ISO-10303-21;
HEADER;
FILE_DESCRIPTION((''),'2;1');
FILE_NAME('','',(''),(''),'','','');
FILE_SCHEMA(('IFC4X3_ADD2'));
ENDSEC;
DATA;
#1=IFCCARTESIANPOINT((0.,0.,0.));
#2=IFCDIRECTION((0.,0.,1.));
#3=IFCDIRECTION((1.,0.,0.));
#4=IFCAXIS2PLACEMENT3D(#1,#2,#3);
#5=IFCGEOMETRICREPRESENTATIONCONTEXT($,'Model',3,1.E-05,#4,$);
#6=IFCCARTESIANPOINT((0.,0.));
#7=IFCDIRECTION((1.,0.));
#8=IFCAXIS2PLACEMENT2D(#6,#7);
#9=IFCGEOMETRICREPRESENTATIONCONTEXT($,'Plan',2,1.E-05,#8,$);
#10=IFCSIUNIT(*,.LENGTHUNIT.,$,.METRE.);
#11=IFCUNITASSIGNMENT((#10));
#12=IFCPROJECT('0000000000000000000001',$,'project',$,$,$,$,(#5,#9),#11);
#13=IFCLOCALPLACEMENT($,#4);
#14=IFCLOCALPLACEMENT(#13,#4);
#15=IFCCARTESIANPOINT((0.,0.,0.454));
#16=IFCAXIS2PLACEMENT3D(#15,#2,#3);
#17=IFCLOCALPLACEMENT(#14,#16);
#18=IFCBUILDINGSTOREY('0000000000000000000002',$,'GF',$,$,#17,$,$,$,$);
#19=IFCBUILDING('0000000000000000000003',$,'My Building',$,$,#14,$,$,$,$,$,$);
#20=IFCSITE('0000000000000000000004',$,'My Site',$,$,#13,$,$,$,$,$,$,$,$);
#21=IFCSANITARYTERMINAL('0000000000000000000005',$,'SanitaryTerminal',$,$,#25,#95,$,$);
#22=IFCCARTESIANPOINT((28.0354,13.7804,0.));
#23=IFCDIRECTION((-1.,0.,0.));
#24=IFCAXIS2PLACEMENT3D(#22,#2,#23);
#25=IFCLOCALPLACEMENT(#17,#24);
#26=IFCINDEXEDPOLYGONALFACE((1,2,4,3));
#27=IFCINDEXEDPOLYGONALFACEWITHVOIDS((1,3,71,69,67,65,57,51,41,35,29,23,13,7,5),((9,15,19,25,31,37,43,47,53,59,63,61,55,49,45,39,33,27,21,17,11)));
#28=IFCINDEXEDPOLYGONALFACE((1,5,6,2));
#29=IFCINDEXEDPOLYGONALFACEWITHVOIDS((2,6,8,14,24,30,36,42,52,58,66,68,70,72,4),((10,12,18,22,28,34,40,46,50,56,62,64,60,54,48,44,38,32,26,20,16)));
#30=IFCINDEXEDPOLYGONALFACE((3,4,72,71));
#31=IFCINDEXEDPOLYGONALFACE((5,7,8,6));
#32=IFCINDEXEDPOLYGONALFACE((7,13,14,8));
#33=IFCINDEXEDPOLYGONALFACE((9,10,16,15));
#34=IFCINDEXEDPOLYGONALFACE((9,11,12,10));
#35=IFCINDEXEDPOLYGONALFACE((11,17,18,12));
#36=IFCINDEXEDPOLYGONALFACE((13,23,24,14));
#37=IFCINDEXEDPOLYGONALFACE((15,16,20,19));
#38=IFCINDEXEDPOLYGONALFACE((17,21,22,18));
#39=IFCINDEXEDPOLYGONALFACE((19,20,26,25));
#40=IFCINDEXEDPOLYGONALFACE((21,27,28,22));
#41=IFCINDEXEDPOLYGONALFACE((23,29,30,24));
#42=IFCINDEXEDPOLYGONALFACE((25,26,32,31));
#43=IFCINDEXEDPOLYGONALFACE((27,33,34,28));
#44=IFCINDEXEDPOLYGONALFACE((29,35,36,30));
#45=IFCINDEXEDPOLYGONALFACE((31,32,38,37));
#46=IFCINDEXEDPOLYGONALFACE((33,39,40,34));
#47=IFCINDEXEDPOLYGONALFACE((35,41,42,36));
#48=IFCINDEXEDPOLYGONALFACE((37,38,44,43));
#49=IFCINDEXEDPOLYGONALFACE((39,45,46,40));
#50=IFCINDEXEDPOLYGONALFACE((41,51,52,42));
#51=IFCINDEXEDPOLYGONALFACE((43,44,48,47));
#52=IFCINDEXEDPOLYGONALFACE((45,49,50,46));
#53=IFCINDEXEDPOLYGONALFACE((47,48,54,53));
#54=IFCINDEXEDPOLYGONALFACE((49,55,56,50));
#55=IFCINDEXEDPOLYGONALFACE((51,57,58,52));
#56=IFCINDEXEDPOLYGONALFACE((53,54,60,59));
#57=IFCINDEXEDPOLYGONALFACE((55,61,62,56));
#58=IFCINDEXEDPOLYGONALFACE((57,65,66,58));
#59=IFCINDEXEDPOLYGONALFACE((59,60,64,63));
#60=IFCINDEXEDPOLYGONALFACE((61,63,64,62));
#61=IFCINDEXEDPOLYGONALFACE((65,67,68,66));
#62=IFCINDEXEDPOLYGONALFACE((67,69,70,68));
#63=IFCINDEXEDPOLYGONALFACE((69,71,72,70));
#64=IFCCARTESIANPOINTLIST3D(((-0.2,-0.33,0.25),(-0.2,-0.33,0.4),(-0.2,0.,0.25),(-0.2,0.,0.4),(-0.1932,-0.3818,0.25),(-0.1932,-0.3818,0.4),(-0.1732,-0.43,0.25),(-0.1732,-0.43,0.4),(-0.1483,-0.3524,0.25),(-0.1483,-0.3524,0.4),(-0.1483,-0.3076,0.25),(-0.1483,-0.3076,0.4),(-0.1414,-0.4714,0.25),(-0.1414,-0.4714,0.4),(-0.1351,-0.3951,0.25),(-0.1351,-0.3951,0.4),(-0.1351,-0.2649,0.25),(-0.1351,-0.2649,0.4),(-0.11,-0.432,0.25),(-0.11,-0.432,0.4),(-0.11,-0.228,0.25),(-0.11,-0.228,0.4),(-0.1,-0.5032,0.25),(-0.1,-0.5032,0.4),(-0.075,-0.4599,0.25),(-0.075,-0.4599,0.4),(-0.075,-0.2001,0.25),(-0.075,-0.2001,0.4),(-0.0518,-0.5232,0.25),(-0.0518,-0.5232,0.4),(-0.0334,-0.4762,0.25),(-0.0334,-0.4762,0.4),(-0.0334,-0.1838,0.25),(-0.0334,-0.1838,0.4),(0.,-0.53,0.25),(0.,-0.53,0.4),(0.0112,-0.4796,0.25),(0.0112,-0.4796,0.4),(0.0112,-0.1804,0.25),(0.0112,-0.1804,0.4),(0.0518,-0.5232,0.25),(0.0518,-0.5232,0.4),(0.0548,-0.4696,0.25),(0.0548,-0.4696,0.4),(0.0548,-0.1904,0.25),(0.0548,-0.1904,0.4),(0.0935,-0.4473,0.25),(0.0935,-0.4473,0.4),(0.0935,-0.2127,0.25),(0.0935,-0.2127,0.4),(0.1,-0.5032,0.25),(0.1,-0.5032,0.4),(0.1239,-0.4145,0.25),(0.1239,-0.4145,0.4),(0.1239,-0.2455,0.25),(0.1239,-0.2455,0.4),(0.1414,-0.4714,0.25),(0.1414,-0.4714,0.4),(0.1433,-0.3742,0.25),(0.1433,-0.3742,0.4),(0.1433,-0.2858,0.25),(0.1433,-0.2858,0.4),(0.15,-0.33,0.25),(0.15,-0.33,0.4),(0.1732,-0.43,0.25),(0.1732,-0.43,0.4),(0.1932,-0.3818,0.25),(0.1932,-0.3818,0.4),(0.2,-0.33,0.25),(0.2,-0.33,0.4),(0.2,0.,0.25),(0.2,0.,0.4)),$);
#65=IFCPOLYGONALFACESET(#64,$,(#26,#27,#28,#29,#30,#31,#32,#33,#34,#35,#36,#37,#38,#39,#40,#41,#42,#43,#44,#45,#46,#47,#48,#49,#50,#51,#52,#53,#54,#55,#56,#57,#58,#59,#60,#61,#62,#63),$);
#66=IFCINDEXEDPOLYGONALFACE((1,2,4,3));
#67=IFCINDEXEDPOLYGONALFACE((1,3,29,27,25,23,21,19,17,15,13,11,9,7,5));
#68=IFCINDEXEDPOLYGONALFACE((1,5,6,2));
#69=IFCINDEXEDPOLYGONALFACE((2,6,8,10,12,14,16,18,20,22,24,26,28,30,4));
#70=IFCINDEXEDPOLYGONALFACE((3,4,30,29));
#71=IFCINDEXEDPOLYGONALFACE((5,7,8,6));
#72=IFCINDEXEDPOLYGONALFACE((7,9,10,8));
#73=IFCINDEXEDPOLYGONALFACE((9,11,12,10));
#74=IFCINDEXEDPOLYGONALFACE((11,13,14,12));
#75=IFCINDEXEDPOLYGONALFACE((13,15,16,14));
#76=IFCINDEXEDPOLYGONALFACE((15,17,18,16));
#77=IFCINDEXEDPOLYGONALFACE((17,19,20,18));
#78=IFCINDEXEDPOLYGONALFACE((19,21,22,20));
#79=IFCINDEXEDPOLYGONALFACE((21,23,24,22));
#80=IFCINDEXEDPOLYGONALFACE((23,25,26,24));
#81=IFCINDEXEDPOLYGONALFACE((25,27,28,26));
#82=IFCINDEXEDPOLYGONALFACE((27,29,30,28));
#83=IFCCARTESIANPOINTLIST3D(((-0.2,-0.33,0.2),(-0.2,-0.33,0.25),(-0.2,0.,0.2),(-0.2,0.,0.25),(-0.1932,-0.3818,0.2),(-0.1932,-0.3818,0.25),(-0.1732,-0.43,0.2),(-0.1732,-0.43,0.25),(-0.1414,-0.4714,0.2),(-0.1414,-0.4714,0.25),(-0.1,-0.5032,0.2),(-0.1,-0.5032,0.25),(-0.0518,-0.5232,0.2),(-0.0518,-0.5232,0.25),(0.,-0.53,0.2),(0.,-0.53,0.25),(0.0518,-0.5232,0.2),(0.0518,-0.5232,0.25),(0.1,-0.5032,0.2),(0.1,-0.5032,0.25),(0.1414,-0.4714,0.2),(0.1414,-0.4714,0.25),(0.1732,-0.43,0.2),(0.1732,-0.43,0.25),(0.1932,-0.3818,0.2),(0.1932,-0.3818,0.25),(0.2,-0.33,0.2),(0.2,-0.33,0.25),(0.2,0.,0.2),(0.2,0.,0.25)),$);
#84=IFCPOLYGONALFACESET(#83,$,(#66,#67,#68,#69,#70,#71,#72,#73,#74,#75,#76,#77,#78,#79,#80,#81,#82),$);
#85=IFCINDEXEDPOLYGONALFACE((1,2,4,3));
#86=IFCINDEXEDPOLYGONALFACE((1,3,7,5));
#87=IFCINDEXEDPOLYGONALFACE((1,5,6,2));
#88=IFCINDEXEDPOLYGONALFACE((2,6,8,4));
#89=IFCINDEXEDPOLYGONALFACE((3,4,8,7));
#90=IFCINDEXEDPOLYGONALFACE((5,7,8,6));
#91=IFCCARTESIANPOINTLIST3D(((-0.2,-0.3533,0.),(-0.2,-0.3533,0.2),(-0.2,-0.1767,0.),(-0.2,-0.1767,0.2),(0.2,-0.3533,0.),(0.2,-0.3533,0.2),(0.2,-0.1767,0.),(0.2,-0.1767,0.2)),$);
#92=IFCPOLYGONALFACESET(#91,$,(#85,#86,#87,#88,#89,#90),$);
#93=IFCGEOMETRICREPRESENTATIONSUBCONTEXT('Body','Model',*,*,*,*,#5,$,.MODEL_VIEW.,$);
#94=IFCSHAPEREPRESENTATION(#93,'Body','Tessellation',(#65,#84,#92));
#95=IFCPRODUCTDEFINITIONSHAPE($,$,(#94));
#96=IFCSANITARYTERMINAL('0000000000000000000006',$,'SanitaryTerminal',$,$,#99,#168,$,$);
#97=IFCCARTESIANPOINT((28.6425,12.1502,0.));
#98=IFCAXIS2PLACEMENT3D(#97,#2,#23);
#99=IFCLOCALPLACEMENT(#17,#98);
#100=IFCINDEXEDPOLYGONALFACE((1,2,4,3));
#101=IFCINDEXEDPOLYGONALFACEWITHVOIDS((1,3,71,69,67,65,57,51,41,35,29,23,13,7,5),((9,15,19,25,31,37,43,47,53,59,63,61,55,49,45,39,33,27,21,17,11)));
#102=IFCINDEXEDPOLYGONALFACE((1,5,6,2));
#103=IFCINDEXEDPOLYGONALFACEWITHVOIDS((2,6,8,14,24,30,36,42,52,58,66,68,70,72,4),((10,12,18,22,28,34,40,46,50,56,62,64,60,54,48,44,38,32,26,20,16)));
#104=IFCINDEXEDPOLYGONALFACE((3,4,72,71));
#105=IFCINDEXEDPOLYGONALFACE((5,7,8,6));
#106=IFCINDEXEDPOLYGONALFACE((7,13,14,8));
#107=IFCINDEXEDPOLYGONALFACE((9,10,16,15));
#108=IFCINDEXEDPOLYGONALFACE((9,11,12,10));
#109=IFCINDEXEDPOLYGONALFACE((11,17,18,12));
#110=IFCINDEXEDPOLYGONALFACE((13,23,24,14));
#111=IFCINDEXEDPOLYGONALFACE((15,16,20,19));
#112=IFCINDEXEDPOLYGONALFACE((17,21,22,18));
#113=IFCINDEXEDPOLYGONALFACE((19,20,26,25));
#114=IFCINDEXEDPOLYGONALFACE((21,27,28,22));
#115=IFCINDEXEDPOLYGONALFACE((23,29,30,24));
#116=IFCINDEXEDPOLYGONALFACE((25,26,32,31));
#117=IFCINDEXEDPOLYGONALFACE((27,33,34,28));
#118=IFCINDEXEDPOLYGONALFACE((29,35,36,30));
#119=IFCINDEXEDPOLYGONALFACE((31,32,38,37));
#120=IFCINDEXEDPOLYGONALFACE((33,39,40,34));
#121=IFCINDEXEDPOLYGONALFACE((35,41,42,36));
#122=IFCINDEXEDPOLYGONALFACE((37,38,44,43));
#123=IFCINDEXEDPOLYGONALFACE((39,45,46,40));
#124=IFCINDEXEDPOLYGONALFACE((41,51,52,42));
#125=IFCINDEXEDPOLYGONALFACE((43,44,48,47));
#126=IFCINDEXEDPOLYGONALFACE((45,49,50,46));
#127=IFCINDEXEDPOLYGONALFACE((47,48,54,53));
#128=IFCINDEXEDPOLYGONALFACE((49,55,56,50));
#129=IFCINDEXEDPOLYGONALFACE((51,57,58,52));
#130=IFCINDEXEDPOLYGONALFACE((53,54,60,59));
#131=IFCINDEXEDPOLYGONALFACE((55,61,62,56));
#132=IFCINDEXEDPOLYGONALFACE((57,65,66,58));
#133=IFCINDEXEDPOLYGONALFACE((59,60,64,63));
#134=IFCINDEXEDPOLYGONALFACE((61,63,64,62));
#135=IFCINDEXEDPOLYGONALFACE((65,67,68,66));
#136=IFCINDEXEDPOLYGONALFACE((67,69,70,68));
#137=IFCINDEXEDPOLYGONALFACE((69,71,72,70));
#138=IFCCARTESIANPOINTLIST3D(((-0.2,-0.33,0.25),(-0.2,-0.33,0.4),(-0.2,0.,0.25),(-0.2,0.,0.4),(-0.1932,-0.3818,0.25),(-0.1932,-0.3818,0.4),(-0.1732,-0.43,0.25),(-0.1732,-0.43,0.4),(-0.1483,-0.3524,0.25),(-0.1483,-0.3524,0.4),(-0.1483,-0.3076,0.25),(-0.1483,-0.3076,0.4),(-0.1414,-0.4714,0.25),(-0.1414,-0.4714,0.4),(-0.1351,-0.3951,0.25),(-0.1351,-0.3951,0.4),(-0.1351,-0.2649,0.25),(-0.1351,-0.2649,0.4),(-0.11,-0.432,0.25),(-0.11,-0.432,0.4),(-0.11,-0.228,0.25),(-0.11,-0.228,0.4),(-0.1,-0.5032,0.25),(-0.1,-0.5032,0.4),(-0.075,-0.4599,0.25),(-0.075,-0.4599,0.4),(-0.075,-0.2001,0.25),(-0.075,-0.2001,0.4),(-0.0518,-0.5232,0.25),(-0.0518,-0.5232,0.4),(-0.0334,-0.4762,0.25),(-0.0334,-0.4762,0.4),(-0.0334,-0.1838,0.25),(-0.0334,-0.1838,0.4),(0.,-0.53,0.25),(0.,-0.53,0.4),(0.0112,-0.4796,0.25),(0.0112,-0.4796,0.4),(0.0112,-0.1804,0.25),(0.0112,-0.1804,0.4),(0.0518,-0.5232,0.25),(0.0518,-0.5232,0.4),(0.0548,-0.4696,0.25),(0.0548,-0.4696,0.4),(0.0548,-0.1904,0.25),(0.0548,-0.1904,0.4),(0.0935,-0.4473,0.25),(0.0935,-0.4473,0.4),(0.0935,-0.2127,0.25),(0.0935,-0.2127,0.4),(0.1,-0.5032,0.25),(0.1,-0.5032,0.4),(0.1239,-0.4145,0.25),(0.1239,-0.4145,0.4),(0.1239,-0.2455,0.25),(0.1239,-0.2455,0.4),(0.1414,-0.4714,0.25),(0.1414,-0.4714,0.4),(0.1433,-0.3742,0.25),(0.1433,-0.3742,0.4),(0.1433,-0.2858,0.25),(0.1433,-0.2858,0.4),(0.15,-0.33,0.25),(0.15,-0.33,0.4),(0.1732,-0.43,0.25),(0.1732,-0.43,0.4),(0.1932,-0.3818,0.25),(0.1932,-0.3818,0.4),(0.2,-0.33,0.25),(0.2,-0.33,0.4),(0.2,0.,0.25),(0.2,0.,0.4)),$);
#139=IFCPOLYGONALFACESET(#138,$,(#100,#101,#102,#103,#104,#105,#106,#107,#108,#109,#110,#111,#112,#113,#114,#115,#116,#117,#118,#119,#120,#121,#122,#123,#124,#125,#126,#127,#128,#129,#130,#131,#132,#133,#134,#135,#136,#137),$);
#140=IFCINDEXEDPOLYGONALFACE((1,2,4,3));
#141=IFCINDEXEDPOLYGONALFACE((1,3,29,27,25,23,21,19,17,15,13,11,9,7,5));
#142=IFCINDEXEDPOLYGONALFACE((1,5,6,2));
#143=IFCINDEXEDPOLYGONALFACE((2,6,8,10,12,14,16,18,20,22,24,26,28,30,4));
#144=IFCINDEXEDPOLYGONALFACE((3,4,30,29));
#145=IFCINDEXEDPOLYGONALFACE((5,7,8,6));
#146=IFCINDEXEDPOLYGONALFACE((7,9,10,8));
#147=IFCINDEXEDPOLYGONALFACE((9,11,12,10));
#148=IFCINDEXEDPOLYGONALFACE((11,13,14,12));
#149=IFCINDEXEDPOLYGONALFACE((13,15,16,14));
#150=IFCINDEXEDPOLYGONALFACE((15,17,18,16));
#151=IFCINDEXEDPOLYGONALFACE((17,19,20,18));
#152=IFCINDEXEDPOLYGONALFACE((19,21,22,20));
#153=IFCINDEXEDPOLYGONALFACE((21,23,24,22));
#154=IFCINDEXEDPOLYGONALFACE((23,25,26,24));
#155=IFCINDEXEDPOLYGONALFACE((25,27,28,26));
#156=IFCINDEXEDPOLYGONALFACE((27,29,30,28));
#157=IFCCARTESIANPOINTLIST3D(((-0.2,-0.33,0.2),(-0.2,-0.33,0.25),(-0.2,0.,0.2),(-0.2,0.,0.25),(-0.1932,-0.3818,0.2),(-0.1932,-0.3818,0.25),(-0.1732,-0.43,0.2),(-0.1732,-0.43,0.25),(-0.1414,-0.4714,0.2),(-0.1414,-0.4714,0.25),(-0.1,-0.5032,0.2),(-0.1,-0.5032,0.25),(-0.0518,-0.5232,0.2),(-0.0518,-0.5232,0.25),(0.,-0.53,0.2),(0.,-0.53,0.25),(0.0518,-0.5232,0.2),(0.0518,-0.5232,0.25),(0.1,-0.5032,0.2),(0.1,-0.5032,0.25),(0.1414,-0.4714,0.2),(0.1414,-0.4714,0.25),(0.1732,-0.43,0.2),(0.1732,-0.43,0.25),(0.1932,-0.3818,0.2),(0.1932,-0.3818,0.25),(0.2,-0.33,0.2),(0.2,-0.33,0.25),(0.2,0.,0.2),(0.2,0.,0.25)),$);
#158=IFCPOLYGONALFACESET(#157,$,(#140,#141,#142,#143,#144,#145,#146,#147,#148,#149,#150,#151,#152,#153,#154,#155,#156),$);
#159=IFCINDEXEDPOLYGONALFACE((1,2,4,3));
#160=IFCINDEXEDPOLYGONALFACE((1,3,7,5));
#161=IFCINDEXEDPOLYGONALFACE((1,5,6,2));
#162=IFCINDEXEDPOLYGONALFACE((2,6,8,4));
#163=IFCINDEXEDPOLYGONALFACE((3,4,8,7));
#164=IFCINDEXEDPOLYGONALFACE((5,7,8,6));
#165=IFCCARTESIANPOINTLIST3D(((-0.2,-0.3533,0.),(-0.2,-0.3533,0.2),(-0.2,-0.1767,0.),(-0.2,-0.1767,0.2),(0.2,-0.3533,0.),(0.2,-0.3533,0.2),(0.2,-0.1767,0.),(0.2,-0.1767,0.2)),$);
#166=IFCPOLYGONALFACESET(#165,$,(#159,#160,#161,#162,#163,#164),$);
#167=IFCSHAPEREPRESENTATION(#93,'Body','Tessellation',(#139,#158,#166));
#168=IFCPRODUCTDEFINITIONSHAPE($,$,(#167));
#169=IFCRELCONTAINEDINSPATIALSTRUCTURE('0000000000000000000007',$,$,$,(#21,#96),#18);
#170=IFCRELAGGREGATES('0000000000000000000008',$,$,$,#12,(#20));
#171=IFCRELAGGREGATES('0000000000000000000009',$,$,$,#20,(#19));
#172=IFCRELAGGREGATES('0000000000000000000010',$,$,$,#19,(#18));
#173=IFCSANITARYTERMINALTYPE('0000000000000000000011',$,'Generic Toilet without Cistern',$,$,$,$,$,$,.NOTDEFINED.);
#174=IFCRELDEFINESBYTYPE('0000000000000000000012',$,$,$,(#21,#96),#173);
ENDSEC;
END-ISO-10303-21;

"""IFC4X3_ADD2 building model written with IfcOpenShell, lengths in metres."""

from ifc_helpers import new_model, entity, si_unit, frame, frame_2d, origin_with_axes, origin_2d_with_axis, place, context, subcontext, project, spatial, line, arc, indexed_curve, circle_curve, outline, extrude, shape, source, transform, mapped, type_object, type_shapes, element, save


model = new_model("IFC4X3_ADD2")

# Units and contexts
model_context = context("Model", 3, precision=1e-05, world=origin_with_axes())
plan_context = context("Plan", 2, precision=1e-05, world=origin_2d_with_axis())
body_context_1 = subcontext(model_context, "Body", "Model", "MODEL_VIEW")
body_context_2 = subcontext(plan_context, "Body", "Plan", "PLAN_VIEW")
ifc_project = project(units=[si_unit("LENGTHUNIT", "METRE")], contexts=[model_context, plan_context])

# Site, building, storey
site_placement = place(None, origin_with_axes())
site = spatial("IfcSite", under=ifc_project, at=site_placement, Name="My Site")
building_placement = place(site_placement, origin_with_axes())
building = spatial("IfcBuilding", under=site, at=building_placement, Name="My Building")
storey_placement = place(building_placement, frame((0.0, 0.0, 0.454), z_axis=(0.0, 0.0, 1.0), x_axis=(1.0, 0.0, 0.0)))
storey = spatial("IfcBuildingStorey", under=building, at=storey_placement, Name="GF")

# Sanitary terminals
sanitary_terminal_type_1 = type_object("IfcSanitaryTerminalType", Name="Generic Toilet without Cistern", PredefinedType="NOTDEFINED")
shared_shape_1 = source(origin_with_axes(), body_context_1, "Body", "SweptSolid", [
    extrude(outline(indexed_curve([(-0.2, 0.0), (0.2, 0.0), (0.2, -0.33), (0.1414, -0.4714), (0.0, -0.53), (-0.1414, -0.4714), (-0.2, -0.33)], segments=[line(1, 2), line(2, 3), arc(3, 4, 5), arc(5, 6, 7), line(7, 1)]), holes=[circle_curve(frame_2d((0.0, -0.33)), 0.15)]), frame((0.0, 0.0, 0.25), z_axis=(0.0, 0.0, 1.0), x_axis=(1.0, 0.0, 0.0)), (0.0, 0.0, 1.0), 0.15),
    extrude(outline(indexed_curve([(-0.2, 0.0), (0.2, 0.0), (0.2, -0.33), (0.1414, -0.4714), (0.0, -0.53), (-0.1414, -0.4714), (-0.2, -0.33)], segments=[line(1, 2), line(2, 3), arc(3, 4, 5), arc(5, 6, 7), line(7, 1)])), frame((0.0, 0.0, 0.2), z_axis=(0.0, 0.0, 1.0), x_axis=(1.0, 0.0, 0.0)), (0.0, 0.0, 1.0), 0.05),
    extrude(outline(indexed_curve([(-0.2, -0.1767), (0.2, -0.1767), (0.2, -0.3533), (-0.2, -0.3533)], segments=[line(1, 2, 3, 4, 1)])), origin_with_axes(), (0.0, 0.0, 1.0), 0.2),
])
shared_shape_2 = source(origin_with_axes(), body_context_2, "Body", "Annotation2D", [
    entity("IfcGeometricCurveSet", [entity("IfcIndexedPolyCurve", entity("IfcCartesianPointList2D", [[-0.1068, -0.124], [-0.0957, -0.1129], [-0.0804, -0.1088], [0.0804, -0.1088], [0.0957, -0.1129], [0.1068, -0.124], [0.1109, -0.1393], [0.1109, -0.3476], [0.1025, -0.3926], [0.0784, -0.4308], [0.0424, -0.4563], [0.0, -0.4652], [-0.0424, -0.4563], [-0.0784, -0.4308], [-0.1025, -0.3926], [-0.1109, -0.3476], [-0.1109, -0.1393]]), [entity("IfcLineIndex", [1, 2, 3, 4, 5, 6, 7, 8, 9, 10, 11, 12, 13, 14, 15, 16, 17, 1])]), entity("IfcIndexedPolyCurve", entity("IfcCartesianPointList2D", [[-0.1962, -0.2314], [-0.1848, -0.301], [-0.1764, -0.3339], [-0.1663, -0.3651], [-0.1546, -0.3944], [-0.1414, -0.4213], [-0.1269, -0.4458], [-0.1111, -0.4675], [-0.0943, -0.4862], [-0.0765, -0.5018], [-0.0581, -0.514], [-0.039, -0.5229], [-0.0196, -0.5282], [0.0, -0.53], [0.0196, -0.5282], [0.039, -0.5229], [0.0581, -0.514], [0.0765, -0.5018], [0.0943, -0.4862], [0.1111, -0.4675], [0.1269, -0.4458], [0.1414, -0.4213], [0.1546, -0.3944], [0.1663, -0.3651], [0.1764, -0.3339], [0.1848, -0.301], [0.1962, -0.2314], [0.2, -0.159], [0.1872, 0.0], [-0.1872, 0.0], [-0.2, -0.159]]), [entity("IfcLineIndex", [1, 2, 3, 4, 5, 6, 7, 8, 9, 10, 11, 12, 13, 14, 15, 16, 17, 18, 19, 20, 21, 22, 23, 24, 25, 26, 27, 28, 29, 30, 31, 1])])]),
])
type_shapes(sanitary_terminal_type_1, [shared_shape_1, shared_shape_2])
for number, where, z_axis, x_axis, name in (
    (1, (28.0354, 13.7804, 0.0), (0.0, 0.0, 1.0), (-1.0, 0.0, 0.0), "SanitaryTerminal"),
    (2, (28.6425, 12.1502, 0.0), (0.0, 0.0, 1.0), (-1.0, 0.0, 0.0), "SanitaryTerminal"),
):
    element("IfcSanitaryTerminal", number, at=place(storey_placement, frame(where, z_axis=z_axis, x_axis=x_axis)), inside=storey, type_object=sanitary_terminal_type_1, Name=name, shapes=[
        shape(body_context_1, "Body", "MappedRepresentation", [mapped(shared_shape_1, transform((0.0, 0.0, 0.0), x_axis=(1.0, 0.0, 0.0), y_axis=(0.0, 1.0, 0.0), z_axis=(0.0, 0.0, 1.0), scale=1.0))]),
        shape(body_context_2, "Body", "MappedRepresentation", [mapped(shared_shape_2, transform((0.0, 0.0, 0.0), x_axis=(1.0, 0.0, 0.0), y_axis=(0.0, 1.0, 0.0), z_axis=(0.0, 0.0, 1.0), scale=1.0))]),
    ])

save(model, "model.ifc")
